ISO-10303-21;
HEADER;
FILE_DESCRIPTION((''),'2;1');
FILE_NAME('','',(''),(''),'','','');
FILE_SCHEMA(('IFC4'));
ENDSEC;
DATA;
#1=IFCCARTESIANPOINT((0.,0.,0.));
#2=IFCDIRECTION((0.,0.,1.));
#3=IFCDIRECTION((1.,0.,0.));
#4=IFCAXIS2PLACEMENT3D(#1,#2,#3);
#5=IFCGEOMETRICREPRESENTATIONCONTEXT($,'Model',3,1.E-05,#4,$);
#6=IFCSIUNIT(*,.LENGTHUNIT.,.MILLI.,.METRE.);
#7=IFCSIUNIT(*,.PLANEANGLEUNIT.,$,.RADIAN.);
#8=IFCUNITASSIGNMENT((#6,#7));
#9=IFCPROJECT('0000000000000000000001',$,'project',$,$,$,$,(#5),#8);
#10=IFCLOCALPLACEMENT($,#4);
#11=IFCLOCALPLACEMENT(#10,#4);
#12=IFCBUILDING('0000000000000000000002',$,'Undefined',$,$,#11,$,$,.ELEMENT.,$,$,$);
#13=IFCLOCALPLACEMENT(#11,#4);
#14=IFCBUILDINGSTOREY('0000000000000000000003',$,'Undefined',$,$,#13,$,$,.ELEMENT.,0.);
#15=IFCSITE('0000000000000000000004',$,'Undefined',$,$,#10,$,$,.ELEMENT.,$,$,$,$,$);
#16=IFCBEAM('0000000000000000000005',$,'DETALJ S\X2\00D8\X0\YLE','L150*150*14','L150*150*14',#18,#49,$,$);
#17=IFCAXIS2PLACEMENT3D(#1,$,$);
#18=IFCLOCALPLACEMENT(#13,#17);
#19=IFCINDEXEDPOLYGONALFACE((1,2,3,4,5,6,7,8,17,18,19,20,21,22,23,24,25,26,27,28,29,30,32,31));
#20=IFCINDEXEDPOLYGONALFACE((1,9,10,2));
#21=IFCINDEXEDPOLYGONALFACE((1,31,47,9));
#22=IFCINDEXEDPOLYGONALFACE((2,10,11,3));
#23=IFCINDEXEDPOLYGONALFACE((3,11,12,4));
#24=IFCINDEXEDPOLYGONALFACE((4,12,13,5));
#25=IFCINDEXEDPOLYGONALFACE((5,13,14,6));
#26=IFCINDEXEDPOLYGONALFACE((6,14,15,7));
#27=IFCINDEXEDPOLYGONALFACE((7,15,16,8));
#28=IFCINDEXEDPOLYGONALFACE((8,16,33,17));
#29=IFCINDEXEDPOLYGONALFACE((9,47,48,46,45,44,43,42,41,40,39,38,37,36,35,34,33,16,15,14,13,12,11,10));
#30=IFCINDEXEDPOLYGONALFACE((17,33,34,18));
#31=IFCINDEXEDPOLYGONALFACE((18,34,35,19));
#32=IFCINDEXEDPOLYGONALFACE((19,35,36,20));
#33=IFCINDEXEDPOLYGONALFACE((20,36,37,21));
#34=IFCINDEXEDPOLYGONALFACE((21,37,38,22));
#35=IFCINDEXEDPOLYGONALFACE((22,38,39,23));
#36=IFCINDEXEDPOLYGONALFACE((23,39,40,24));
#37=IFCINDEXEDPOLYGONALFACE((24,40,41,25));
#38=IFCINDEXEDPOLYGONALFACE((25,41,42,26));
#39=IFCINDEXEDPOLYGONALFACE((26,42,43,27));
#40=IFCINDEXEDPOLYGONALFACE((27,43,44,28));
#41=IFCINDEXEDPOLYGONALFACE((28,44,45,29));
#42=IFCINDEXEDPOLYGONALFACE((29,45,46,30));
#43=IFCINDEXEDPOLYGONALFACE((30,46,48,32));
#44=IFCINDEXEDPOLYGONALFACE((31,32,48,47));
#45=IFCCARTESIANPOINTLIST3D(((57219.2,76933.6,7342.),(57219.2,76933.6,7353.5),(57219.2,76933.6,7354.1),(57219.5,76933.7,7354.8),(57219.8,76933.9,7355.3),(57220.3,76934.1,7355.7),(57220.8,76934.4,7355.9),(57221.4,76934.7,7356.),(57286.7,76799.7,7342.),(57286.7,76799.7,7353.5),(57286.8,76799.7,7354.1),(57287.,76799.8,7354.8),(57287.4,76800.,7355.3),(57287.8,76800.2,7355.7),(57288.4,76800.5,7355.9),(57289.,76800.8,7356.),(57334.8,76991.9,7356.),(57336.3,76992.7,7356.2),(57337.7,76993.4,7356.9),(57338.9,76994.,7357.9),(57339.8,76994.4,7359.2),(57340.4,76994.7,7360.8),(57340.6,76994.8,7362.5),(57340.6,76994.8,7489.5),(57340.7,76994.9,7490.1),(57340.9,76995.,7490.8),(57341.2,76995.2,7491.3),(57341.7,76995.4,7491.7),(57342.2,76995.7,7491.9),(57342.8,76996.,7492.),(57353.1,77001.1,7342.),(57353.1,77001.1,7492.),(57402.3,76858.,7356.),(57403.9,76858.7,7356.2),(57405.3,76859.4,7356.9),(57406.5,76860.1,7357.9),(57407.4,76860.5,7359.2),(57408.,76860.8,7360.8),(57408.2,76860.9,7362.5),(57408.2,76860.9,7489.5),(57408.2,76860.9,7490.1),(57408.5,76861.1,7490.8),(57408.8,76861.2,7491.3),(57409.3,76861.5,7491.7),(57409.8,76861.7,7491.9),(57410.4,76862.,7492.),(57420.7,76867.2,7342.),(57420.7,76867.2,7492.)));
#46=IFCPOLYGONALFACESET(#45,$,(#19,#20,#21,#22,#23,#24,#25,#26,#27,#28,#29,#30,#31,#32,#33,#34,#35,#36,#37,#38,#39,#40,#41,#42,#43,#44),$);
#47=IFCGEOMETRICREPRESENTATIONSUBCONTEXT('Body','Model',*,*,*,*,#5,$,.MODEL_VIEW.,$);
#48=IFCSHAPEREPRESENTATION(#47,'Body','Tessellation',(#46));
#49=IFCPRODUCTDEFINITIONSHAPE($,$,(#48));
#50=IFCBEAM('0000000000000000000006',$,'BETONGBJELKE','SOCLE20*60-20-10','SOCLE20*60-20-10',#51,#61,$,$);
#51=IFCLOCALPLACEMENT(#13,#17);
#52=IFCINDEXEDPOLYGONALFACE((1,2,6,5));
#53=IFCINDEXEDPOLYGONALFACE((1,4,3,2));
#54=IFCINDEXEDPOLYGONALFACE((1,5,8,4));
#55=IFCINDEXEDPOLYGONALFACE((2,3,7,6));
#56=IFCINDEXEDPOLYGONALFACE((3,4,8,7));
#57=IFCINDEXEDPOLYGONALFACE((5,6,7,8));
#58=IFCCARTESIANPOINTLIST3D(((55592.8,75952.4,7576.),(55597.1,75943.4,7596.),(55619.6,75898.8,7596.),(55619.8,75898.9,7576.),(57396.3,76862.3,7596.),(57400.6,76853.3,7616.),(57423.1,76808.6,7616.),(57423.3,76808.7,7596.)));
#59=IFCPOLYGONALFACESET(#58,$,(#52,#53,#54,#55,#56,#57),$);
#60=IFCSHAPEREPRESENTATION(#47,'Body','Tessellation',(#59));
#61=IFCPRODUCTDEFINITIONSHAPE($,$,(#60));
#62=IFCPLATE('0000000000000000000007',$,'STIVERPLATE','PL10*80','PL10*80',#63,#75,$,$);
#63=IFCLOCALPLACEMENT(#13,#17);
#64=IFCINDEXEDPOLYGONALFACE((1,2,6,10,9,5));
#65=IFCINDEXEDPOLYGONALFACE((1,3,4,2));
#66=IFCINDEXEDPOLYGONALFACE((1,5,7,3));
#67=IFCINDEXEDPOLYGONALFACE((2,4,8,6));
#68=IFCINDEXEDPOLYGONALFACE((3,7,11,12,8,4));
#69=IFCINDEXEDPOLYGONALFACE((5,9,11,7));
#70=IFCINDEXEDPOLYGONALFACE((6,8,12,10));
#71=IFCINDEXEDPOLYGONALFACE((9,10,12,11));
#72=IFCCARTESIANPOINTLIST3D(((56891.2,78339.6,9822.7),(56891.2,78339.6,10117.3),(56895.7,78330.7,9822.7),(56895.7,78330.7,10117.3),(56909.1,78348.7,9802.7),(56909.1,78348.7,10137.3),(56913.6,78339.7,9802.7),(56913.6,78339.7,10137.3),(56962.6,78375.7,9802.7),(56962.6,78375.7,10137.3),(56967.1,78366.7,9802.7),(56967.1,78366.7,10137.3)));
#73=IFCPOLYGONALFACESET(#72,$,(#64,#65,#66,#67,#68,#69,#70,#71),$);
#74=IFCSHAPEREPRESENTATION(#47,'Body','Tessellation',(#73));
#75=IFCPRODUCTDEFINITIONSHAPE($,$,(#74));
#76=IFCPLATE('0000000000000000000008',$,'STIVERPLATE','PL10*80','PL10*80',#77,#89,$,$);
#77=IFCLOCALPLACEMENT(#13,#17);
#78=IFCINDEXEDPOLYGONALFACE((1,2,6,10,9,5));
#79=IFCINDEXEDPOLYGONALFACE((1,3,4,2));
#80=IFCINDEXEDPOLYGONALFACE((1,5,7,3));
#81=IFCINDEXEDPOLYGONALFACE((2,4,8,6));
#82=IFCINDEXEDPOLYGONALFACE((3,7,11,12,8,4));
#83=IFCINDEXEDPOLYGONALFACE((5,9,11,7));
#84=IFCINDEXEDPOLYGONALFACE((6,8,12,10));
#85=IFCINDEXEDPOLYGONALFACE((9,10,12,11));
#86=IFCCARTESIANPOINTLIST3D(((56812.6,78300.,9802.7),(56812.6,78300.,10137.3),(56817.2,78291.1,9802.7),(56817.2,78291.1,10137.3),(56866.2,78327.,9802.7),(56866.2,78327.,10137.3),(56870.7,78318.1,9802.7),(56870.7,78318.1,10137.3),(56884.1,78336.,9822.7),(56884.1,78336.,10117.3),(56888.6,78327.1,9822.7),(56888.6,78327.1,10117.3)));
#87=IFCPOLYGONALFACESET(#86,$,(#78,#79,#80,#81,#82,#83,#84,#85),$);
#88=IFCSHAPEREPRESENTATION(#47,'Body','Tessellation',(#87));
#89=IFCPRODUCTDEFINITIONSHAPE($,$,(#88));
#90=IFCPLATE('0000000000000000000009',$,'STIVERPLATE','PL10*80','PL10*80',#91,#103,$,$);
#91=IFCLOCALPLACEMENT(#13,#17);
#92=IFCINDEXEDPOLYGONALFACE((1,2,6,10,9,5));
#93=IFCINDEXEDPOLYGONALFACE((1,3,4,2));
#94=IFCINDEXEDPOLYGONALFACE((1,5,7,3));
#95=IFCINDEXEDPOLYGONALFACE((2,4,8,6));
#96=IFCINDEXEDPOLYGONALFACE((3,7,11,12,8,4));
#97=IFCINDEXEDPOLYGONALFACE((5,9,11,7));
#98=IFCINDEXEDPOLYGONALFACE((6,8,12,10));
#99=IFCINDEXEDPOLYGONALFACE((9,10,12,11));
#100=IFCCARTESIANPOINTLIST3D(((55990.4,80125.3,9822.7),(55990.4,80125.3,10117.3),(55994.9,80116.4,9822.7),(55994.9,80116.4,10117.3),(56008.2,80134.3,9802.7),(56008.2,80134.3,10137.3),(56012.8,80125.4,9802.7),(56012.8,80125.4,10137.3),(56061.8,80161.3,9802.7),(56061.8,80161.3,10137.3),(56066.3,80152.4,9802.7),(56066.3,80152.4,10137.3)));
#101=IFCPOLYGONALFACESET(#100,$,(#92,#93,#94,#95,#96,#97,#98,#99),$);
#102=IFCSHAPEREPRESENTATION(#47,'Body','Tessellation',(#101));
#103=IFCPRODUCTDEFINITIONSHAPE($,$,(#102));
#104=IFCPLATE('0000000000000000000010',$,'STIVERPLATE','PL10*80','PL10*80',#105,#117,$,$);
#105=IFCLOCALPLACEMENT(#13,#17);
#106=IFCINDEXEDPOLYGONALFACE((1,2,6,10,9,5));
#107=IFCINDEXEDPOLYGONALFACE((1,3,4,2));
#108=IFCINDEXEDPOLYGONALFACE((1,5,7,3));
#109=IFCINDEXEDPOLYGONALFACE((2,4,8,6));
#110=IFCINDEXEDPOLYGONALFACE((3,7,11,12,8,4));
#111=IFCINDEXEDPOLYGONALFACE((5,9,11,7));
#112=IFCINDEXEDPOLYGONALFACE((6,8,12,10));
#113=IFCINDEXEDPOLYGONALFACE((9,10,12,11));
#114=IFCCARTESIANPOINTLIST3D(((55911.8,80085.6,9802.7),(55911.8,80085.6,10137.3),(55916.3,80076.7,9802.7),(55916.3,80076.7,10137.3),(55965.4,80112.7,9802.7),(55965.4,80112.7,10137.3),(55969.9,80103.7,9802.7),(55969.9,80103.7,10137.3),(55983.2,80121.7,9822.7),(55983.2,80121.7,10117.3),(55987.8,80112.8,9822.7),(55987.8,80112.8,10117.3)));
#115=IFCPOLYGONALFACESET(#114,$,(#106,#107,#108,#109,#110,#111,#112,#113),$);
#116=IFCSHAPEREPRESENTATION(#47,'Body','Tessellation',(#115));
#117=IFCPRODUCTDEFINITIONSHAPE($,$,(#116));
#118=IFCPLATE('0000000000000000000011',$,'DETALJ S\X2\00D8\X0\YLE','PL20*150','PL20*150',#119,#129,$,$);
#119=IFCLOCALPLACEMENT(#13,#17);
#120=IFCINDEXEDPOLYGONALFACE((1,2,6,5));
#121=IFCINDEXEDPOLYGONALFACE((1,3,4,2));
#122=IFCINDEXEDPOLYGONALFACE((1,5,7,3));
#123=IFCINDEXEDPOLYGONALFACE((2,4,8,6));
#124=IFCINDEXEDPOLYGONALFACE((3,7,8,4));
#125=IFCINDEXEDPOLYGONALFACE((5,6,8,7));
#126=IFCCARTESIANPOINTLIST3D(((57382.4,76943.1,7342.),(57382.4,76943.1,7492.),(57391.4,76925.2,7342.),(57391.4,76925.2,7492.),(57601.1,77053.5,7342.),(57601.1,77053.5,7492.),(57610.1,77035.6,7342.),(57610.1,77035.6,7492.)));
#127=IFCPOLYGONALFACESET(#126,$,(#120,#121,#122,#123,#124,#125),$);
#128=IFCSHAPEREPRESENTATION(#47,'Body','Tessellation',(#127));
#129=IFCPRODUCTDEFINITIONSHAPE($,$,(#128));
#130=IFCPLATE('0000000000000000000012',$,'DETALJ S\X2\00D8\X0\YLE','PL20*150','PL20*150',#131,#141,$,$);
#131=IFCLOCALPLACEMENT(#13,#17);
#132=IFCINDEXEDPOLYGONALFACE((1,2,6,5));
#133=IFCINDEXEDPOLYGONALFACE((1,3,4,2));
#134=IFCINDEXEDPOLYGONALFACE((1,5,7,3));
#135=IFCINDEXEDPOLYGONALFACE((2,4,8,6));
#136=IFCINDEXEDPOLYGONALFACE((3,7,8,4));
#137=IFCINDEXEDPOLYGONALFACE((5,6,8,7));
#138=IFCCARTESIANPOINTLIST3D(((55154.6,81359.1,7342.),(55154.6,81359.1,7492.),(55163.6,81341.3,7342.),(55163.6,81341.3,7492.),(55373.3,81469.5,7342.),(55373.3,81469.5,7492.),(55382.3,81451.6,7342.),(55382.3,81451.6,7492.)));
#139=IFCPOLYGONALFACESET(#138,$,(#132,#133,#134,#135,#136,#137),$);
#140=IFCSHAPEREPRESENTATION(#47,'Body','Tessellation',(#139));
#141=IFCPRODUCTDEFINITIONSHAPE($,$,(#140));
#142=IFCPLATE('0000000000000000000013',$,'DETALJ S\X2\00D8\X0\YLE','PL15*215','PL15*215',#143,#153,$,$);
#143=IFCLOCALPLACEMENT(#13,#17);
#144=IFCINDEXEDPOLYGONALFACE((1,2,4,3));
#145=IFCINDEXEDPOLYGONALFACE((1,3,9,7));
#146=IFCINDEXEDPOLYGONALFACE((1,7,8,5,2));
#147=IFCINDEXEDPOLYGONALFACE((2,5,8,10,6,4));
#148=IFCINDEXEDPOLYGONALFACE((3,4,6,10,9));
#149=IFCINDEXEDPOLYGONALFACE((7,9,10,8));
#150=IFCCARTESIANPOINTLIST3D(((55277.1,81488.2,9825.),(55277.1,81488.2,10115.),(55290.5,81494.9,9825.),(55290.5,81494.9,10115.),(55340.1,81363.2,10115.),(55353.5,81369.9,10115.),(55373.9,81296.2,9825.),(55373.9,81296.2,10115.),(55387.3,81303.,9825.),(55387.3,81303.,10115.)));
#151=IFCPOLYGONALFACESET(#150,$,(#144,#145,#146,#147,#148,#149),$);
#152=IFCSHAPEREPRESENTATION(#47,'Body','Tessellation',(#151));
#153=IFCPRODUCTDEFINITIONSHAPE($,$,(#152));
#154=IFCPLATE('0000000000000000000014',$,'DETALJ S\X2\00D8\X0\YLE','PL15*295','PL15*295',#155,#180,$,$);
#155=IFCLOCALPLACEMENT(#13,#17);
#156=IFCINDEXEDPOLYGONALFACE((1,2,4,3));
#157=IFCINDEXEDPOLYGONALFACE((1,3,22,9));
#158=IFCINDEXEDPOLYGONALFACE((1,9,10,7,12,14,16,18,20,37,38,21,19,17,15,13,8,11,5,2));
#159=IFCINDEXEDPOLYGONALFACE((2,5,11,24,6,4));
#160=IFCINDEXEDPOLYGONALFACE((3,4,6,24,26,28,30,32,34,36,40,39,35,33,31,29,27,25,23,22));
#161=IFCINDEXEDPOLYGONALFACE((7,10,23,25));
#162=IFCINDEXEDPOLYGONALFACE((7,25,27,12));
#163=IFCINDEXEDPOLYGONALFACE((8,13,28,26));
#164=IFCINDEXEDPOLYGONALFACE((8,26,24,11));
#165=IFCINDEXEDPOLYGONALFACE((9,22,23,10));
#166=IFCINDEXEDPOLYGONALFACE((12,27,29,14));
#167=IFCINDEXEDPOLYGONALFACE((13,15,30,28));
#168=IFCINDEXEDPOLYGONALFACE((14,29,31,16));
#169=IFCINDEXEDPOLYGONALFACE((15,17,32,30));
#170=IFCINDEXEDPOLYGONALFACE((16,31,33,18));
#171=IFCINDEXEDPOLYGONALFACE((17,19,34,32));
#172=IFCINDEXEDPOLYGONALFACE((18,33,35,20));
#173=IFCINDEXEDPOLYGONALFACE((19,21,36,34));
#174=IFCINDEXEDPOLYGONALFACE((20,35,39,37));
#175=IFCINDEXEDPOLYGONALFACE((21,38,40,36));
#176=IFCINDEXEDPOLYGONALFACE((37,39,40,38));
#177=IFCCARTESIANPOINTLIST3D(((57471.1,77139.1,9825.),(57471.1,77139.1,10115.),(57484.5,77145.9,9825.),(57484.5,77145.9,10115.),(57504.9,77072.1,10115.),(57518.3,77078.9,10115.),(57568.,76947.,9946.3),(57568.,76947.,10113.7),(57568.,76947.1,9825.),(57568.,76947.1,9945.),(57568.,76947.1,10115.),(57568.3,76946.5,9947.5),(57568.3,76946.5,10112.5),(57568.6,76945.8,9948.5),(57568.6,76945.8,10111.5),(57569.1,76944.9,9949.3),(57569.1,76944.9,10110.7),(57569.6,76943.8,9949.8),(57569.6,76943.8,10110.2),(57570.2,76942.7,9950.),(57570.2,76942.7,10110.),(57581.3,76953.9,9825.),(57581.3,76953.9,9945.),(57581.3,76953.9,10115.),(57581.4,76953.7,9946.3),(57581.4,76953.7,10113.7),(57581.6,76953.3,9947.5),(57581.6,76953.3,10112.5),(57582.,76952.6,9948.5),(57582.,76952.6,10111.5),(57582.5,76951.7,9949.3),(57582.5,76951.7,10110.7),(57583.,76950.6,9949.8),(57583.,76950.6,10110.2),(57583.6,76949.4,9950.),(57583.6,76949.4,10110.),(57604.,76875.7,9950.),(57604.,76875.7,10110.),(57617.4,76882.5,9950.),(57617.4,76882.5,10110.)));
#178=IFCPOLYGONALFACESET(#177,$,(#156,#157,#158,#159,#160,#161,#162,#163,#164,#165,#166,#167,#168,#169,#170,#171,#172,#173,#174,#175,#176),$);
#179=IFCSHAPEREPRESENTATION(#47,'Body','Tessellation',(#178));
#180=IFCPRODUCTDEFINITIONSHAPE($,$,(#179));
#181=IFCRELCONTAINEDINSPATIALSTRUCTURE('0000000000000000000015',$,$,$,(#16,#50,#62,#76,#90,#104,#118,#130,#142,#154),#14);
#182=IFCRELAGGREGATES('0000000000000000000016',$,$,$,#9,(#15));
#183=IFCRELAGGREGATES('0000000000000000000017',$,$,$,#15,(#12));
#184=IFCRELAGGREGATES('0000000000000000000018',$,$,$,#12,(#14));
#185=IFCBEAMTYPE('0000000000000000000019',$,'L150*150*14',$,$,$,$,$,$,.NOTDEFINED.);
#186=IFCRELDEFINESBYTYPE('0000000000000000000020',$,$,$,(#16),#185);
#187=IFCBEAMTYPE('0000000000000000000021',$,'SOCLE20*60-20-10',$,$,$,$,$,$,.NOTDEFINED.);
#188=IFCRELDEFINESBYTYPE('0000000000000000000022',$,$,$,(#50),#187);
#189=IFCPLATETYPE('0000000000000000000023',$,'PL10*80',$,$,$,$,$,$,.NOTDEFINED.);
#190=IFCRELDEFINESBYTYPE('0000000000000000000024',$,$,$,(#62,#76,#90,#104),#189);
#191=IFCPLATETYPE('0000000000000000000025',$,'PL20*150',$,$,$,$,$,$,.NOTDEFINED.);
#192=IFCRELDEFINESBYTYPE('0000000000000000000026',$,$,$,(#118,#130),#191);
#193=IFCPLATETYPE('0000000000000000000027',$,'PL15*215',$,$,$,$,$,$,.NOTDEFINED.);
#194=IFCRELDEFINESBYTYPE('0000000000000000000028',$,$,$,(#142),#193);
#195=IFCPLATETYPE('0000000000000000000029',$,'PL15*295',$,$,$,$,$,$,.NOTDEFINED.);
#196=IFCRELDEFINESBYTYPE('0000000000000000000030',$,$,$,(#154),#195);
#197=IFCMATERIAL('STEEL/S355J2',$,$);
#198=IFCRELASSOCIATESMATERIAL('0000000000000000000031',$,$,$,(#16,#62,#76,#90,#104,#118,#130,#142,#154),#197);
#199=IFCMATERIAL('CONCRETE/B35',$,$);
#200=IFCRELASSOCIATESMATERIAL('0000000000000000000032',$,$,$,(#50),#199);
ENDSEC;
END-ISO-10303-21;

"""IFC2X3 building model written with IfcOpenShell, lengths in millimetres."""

from ifc_helpers import new_model, si_unit, frame, frame_2d, origin_with_axes, origin_2d_with_axis, place, context, subcontext, project, spatial, polyline, circle_curve, parameter, trimmed, segment, composite_curve, l_section, outline, extrude, material, type_object, element, save


model = new_model("IFC2X3")

# Units and contexts
model_context = context("Model", 3, precision=1e-05, world=origin_with_axes())
body_context = subcontext(model_context, "Body", "Model", "MODEL_VIEW")
ifc_project = project(units=[si_unit("LENGTHUNIT", "METRE", prefix="MILLI"), si_unit("PLANEANGLEUNIT", "RADIAN")], contexts=[model_context])

# Site, building, storey
site_placement = place(None, origin_with_axes())
site = spatial("IfcSite", under=ifc_project, at=site_placement, Name="Undefined", CompositionType="ELEMENT")
building_placement = place(site_placement, origin_with_axes())
building = spatial("IfcBuilding", under=site, at=building_placement, Name="Undefined", CompositionType="ELEMENT")
storey_placement = place(building_placement, origin_with_axes())
storey = spatial("IfcBuildingStorey", under=building, at=storey_placement, Name="Undefined", CompositionType="ELEMENT", Elevation=0.0)

# Shared definitions
ifc_material_1 = material(Name="STEEL/S355J2")

# Beams
beam_type_1 = type_object("IfcBeamType", Name="L150*150*14", PredefinedType="NOTDEFINED")
beam_1_placement = place(storey_placement, frame((57286.1, 76967.4, 7417.0), z_axis=(0.0, 0.0, 1.0), x_axis=(0.450416, -0.892819, 0.0)))
element("IfcBeam", 1, at=beam_1_placement, inside=storey, type_object=beam_type_1, material=ifc_material_1, Name="DETALJ SØYLE", Description="L150*150*14", ObjectType="L150*150*14", context=body_context, shape_type="SweptSolid", body=[
    extrude(l_section(Depth=150.0, Width=150.0, Thickness=14.0, FilletRadius=6.5, EdgeRadius=2.5, at=origin_2d_with_axis()), frame((150.0, 0.0, 0.0), z_axis=(-1.0, 0.0, 0.0), x_axis=(0.0, -1.0, 0.0)), (0.0, 0.0, 1.0), 150.0),
])
ifc_material_2 = material(Name="CONCRETE/B35")
beam_type_2 = type_object("IfcBeamType", Name="SOCLE20*60-20-10", PredefinedType="NOTDEFINED")
beam_2_placement = place(storey_placement, frame((57409.7, 76835.4, 7606.0), z_axis=(-0.008839, -0.004459, 0.999951), x_axis=(-0.892778, -0.450388, -0.009901)))
element("IfcBeam", 2, at=beam_2_placement, inside=storey, type_object=beam_type_2, material=ifc_material_2, Name="BETONGBJELKE", Description="SOCLE20*60-20-10", ObjectType="SOCLE20*60-20-10", context=body_context, shape_type="SweptSolid", body=[
    extrude(outline(polyline([(30.0, -10.0), (-30.0, -10.0), (-30.0, 10.0), (20.0, 10.0), (30.0, -10.0)])), frame((2020.1, 0.0, 0.0), z_axis=(-1.0, 0.0, 0.0), x_axis=(0.0, -1.0, 0.0)), (0.0, 0.0, 1.0), 2020.1),
])

# Plates
plate_type_1 = type_object("IfcPlateType", Name="PL10*80", PredefinedType="NOTDEFINED")
plate_1_placement = place(storey_placement, frame((56964.9, 78371.2, 9802.7), z_axis=(-0.450412, 0.892821, 0.0), x_axis=(-0.892821, -0.450412, 0.0)))
element("IfcPlate", 3, at=plate_1_placement, inside=storey, type_object=plate_type_1, material=ifc_material_1, Name="STIVERPLATE", Description="PL10*80", ObjectType="PL10*80", context=body_context, shape_type="SweptSolid", body=[
    extrude(outline(polyline([(0.0, 0.0), (60.0, 0.0), (80.0, 20.0), (80.0, 314.6), (60.0, 334.6), (0.0, 334.6), (0.0, 0.0)])), frame((0.0, 0.0, -5.0), z_axis=(0.0, 0.0, 1.0), x_axis=(1.0, 0.0, 0.0)), (0.0, 0.0, 1.0), 10.0),
])
plate_2_placement = place(storey_placement, frame((56886.3, 78331.6, 9802.7), z_axis=(-0.450412, 0.892821, 0.0), x_axis=(-0.892821, -0.450412, 0.0)))
element("IfcPlate", 4, at=plate_2_placement, inside=storey, type_object=plate_type_1, material=ifc_material_1, Name="STIVERPLATE", Description="PL10*80", ObjectType="PL10*80", context=body_context, shape_type="SweptSolid", body=[
    extrude(outline(polyline([(0.0, 20.0), (20.0, 0.0), (80.0, 0.0), (80.0, 334.6), (20.0, 334.6), (0.0, 314.6), (0.0, 20.0)])), frame((0.0, 0.0, -5.0), z_axis=(0.0, 0.0, 1.0), x_axis=(1.0, 0.0, 0.0)), (0.0, 0.0, 1.0), 10.0),
])
plate_3_placement = place(storey_placement, frame((56064.1, 80156.9, 9802.7), z_axis=(-0.450412, 0.892821, 0.0), x_axis=(-0.892821, -0.450412, 0.0)))
element("IfcPlate", 5, at=plate_3_placement, inside=storey, type_object=plate_type_1, material=ifc_material_1, Name="STIVERPLATE", Description="PL10*80", ObjectType="PL10*80", context=body_context, shape_type="SweptSolid", body=[
    extrude(outline(polyline([(0.0, 0.0), (60.0, 0.0), (80.0, 20.0), (80.0, 314.6), (60.0, 334.6), (0.0, 334.6), (0.0, 0.0)])), frame((0.0, 0.0, -5.0), z_axis=(0.0, 0.0, 1.0), x_axis=(1.0, 0.0, 0.0)), (0.0, 0.0, 1.0), 10.0),
])
plate_4_placement = place(storey_placement, frame((55985.5, 80117.2, 9802.7), z_axis=(-0.450412, 0.892821, 0.0), x_axis=(-0.892821, -0.450412, 0.0)))
element("IfcPlate", 6, at=plate_4_placement, inside=storey, type_object=plate_type_1, material=ifc_material_1, Name="STIVERPLATE", Description="PL10*80", ObjectType="PL10*80", context=body_context, shape_type="SweptSolid", body=[
    extrude(outline(polyline([(0.0, 20.0), (20.0, 0.0), (80.0, 0.0), (80.0, 334.6), (20.0, 334.6), (0.0, 314.6), (0.0, 20.0)])), frame((0.0, 0.0, -5.0), z_axis=(0.0, 0.0, 1.0), x_axis=(1.0, 0.0, 0.0)), (0.0, 0.0, 1.0), 10.0),
])
plate_type_2 = type_object("IfcPlateType", Name="PL20*150", PredefinedType="NOTDEFINED")
plate_5_placement = place(storey_placement, frame((57605.6, 77044.5, 7492.0), z_axis=(0.450411, -0.892821, 0.0), x_axis=(-0.892821, -0.450411, 0.0)))
element("IfcPlate", 7, at=plate_5_placement, inside=storey, type_object=plate_type_2, material=ifc_material_1, Name="DETALJ SØYLE", Description="PL20*150", ObjectType="PL20*150", context=body_context, shape_type="SweptSolid", body=[
    extrude(outline(polyline([(0.0, 0.0), (245.0, 0.0), (245.0, 150.0), (0.0, 150.0), (0.0, 0.0)])), frame((0.0, 0.0, -10.0), z_axis=(0.0, 0.0, 1.0), x_axis=(1.0, 0.0, 0.0)), (0.0, 0.0, 1.0), 20.0),
])
plate_6_placement = place(storey_placement, frame((55377.8, 81460.6, 7492.0), z_axis=(0.450411, -0.892821, 0.0), x_axis=(-0.892821, -0.450411, 0.0)))
element("IfcPlate", 8, at=plate_6_placement, inside=storey, type_object=plate_type_2, material=ifc_material_1, Name="DETALJ SØYLE", Description="PL20*150", ObjectType="PL20*150", context=body_context, shape_type="SweptSolid", body=[
    extrude(outline(polyline([(0.0, 0.0), (245.0, 0.0), (245.0, 150.0), (0.0, 150.0), (0.0, 0.0)])), frame((0.0, 0.0, -10.0), z_axis=(0.0, 0.0, 1.0), x_axis=(1.0, 0.0, 0.0)), (0.0, 0.0, 1.0), 20.0),
])
plate_type_3 = type_object("IfcPlateType", Name="PL15*215", PredefinedType="NOTDEFINED")
plate_7_placement = place(storey_placement, frame((55346.8, 81366.5, 10115.0), z_axis=(-0.892821, -0.450412, 0.0), x_axis=(-0.450412, 0.892821, 0.0)))
element("IfcPlate", 9, at=plate_7_placement, inside=storey, type_object=plate_type_3, material=ifc_material_1, Name="DETALJ SØYLE", Description="PL15*215", ObjectType="PL15*215", context=body_context, shape_type="SweptSolid", body=[
    extrude(outline(polyline([(0.0, 0.0), (140.0, 0.0), (140.0, 290.0), (-75.0, 290.0), (-75.0, 0.0), (0.0, 0.0)])), frame((0.0, 0.0, -7.5), z_axis=(0.0, 0.0, 1.0), x_axis=(1.0, 0.0, 0.0)), (0.0, 0.0, 1.0), 15.0),
])
plate_type_4 = type_object("IfcPlateType", Name="PL15*295", PredefinedType="NOTDEFINED")
plate_8_placement = place(storey_placement, frame((57511.6, 77075.5, 10115.0), z_axis=(0.892821, 0.450412, 0.0), x_axis=(0.450412, -0.892821, 0.0)))
element("IfcPlate", 10, at=plate_8_placement, inside=storey, type_object=plate_type_4, material=ifc_material_1, Name="DETALJ SØYLE", Description="PL15*295", ObjectType="PL15*295", context=body_context, shape_type="SweptSolid", body=[
    extrude(outline(composite_curve([segment(polyline([(0.0, 0.0), (140.0, 0.0)]), True, "CONTINUOUS"), segment(trimmed(circle_curve(frame_2d((145.0, 0.0), x_axis=(-1.0, 0.0)), 5.0), [parameter(0.0)], [parameter(4.712389)], False, "PARAMETER"), True, "CONTINUOUS"), segment(polyline([(145.0, 5.0), (220.0, 5.0), (220.0, 165.0), (145.0, 165.0)]), True, "CONTINUOUS"), segment(trimmed(circle_curve(frame_2d((145.0, 170.0), x_axis=(0.0, -1.0)), 5.0), [parameter(0.0)], [parameter(4.712389)], False, "PARAMETER"), True, "CONTINUOUS"), segment(polyline([(140.0, 170.0), (140.0, 290.0), (-75.0, 290.0), (-75.0, 0.0), (0.0, 0.0)]), True, "CONTINUOUS")], self_intersect=True)), frame((0.0, 0.0, -7.5), z_axis=(0.0, 0.0, 1.0), x_axis=(1.0, 0.0, 0.0)), (0.0, 0.0, 1.0), 15.0),
])

save(model, "model.ifc")
